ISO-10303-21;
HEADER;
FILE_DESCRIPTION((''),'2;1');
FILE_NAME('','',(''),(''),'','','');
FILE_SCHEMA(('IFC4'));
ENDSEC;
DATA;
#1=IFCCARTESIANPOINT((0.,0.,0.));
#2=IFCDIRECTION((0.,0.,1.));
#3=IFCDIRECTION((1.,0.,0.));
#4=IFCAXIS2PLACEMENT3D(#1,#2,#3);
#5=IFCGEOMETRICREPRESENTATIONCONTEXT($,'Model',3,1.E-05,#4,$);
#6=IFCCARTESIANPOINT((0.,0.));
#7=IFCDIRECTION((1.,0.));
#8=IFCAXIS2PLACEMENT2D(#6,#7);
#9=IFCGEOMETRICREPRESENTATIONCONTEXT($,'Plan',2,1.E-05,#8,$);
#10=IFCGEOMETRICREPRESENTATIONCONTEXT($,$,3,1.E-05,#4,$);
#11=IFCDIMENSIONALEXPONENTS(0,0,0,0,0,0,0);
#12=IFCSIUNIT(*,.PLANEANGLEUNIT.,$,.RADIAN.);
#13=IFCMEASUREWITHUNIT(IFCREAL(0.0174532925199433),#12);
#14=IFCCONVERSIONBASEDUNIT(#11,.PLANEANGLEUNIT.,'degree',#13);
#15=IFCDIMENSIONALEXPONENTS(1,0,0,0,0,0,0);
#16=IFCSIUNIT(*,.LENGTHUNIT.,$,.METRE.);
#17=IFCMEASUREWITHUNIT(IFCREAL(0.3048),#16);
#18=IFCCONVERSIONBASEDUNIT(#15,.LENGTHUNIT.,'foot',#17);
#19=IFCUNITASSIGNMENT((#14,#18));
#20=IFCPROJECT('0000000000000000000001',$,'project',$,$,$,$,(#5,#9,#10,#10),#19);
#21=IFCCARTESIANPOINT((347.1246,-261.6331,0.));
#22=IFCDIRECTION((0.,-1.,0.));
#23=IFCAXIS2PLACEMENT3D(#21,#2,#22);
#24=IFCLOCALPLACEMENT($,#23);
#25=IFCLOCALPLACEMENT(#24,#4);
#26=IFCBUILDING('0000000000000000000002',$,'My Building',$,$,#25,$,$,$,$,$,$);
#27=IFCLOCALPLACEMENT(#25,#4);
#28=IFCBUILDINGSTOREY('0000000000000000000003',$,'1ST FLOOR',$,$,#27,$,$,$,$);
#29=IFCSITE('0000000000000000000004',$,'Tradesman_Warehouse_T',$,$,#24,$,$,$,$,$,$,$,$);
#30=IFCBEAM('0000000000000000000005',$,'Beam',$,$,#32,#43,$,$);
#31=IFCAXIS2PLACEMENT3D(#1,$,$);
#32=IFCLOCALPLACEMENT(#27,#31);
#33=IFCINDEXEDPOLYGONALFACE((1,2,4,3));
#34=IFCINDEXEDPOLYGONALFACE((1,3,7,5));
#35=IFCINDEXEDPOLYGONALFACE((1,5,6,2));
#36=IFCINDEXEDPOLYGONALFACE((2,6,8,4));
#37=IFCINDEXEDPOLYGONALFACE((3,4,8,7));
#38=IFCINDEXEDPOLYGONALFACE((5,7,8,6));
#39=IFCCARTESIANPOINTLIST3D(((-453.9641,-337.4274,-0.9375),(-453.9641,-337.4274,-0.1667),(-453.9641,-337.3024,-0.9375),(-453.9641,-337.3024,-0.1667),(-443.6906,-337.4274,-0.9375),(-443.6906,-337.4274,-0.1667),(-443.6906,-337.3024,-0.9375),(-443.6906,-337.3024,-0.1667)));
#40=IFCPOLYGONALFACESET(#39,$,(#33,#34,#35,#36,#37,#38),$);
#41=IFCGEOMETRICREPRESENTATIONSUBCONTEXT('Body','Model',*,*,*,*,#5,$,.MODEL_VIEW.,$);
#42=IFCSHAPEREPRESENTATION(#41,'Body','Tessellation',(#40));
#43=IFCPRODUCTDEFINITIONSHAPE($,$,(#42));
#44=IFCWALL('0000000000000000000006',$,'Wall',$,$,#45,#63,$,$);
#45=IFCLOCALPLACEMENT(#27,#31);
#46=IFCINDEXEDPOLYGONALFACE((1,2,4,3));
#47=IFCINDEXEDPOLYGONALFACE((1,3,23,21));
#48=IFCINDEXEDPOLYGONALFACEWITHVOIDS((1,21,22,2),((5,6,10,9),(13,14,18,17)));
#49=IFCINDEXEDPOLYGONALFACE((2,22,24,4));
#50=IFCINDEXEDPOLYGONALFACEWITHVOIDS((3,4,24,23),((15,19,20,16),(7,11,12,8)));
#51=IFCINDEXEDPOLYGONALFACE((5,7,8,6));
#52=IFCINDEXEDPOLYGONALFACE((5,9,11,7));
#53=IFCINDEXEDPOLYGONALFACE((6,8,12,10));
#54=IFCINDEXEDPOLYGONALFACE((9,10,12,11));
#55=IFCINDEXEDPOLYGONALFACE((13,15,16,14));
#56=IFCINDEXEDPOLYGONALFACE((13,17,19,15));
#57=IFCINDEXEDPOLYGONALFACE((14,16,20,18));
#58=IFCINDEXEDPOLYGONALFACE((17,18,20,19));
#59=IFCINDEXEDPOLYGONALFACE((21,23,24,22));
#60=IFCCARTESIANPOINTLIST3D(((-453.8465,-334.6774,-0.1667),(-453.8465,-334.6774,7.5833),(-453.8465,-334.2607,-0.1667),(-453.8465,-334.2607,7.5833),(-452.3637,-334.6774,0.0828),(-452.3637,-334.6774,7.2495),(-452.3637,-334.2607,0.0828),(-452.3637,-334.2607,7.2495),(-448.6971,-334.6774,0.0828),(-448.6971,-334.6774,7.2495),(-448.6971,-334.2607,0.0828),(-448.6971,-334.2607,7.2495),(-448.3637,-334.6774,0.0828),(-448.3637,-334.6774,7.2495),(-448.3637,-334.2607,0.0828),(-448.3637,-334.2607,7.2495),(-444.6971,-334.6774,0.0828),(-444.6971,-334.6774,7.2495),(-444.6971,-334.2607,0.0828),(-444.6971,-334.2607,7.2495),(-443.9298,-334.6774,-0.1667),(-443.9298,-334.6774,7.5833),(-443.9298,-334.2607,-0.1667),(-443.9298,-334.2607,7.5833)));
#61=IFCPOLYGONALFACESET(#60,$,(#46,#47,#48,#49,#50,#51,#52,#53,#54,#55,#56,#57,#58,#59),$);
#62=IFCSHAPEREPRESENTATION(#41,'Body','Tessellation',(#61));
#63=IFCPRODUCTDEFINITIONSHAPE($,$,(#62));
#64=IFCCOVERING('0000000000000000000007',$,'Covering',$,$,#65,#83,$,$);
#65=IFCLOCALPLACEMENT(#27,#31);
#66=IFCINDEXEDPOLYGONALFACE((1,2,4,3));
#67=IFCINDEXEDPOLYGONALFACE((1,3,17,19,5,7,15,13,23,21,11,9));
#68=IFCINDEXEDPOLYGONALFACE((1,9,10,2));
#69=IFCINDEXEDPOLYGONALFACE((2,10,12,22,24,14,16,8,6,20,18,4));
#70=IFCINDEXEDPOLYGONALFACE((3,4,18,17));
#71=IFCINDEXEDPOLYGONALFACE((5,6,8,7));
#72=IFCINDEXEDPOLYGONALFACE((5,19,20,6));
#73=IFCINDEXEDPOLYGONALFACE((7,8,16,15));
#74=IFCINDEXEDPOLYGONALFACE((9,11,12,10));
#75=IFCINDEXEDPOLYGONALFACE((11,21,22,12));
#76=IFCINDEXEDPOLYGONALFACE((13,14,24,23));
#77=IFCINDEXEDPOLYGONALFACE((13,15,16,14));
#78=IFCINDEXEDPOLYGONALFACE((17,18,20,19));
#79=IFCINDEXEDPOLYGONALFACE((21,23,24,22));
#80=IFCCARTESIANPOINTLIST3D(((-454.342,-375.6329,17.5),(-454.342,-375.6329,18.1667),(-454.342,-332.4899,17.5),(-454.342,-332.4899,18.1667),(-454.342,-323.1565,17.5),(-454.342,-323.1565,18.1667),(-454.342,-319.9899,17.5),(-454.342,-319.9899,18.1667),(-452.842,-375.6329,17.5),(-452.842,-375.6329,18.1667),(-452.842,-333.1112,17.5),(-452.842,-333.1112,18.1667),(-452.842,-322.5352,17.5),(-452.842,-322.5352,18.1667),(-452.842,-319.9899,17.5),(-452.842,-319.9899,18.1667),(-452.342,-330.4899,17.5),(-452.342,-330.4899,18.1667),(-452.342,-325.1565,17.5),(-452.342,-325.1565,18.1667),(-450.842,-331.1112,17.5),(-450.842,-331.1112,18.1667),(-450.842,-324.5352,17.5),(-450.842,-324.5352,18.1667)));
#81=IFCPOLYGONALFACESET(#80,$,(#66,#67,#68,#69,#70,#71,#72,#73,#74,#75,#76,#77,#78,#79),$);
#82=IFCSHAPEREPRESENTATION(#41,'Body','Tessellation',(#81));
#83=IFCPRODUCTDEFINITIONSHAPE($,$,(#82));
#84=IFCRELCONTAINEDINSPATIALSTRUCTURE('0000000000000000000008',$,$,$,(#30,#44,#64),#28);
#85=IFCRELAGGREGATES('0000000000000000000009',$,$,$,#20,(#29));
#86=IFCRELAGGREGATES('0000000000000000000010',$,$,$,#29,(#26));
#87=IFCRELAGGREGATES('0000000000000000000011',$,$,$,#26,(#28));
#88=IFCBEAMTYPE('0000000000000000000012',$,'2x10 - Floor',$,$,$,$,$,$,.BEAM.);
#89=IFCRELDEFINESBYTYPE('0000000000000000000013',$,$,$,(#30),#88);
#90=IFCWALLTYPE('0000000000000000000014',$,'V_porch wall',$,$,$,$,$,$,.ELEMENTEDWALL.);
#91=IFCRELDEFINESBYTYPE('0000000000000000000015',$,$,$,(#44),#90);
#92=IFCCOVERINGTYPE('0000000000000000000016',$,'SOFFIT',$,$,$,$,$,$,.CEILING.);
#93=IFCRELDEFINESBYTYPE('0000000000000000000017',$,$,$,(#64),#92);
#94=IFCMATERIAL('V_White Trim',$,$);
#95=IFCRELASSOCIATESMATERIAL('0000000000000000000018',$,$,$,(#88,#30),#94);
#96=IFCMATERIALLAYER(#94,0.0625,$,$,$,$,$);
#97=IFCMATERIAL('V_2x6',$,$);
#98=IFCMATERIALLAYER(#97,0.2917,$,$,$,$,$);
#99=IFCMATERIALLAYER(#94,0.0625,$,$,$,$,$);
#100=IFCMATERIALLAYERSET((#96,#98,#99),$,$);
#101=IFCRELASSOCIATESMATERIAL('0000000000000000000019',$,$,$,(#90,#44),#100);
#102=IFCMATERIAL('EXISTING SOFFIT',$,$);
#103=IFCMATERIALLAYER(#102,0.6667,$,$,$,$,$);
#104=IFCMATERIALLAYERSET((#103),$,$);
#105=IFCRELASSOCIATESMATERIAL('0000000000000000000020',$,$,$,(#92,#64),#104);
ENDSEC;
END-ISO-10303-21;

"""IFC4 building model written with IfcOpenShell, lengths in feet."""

from ifc_helpers import new_model, entity, si_unit, converted_unit, frame, origin_with_axes, origin_2d_with_axis, place, context, subcontext, project, spatial, line, indexed_curve, rectangle, outline, extrude, source, transform, mapped, material, layer, layer_set, layer_usage, material_profile, profile_set, profile_usage, type_object, element, save


model = new_model("IFC4")

# Units and contexts
model_context = context("Model", 3, precision=1e-05, world=origin_with_axes())
plan_context = context("Plan", 2, precision=1e-05, world=origin_2d_with_axis())
context_of_model = context(None, 3, precision=1e-05, world=origin_with_axes())
body_context = subcontext(model_context, "Body", "Model", "MODEL_VIEW")
ifc_project = project(units=[converted_unit("PLANEANGLEUNIT", "degree", entity("IfcReal", 0.0174532925199433), si_unit("PLANEANGLEUNIT", "RADIAN"), dimensions=[0, 0, 0, 0, 0, 0, 0]), converted_unit("LENGTHUNIT", "foot", entity("IfcReal", 0.3048), si_unit("LENGTHUNIT", "METRE"), dimensions=[1, 0, 0, 0, 0, 0, 0])], contexts=[model_context, plan_context, context_of_model, context_of_model])

# Site, building, storey
site_placement = place(None, frame((347.1246, -261.6331, 0.0), z_axis=(0.0, 0.0, 1.0), x_axis=(0.0, -1.0, 0.0)))
site = spatial("IfcSite", under=ifc_project, at=site_placement, Name="Tradesman_Warehouse_T")
building_placement = place(site_placement, frame((0.0, 0.0, 0.0), z_axis=(0.0, 0.0, 1.0), x_axis=(1.0, 0.0, 0.0)))
building = spatial("IfcBuilding", under=site, at=building_placement, Name="My Building")
storey_placement = place(building_placement, frame((0.0, 0.0, 0.0), z_axis=(0.0, 0.0, 1.0), x_axis=(1.0, 0.0, 0.0)))
storey = spatial("IfcBuildingStorey", under=building, at=storey_placement, Name="1ST FLOOR")

# Beam
ifc_material_1 = material(Name="V_White Trim")
ifc_material_profile_1 = material_profile(ifc_material_1, rectangle(XDim=0.125, YDim=0.7708))
ifc_profile_set_1 = profile_set([ifc_material_profile_1])
beam_type_1 = type_object("IfcBeamType", Name="2x10 - Floor", PredefinedType="BEAM", material=ifc_profile_set_1)
ifc_profile_usage_1 = profile_usage(ifc_profile_set_1, cardinal=5)
beam_1_placement = place(storey_placement, frame((-453.9641, -337.3649, -0.5521), z_axis=(1.0, 0.0, 0.0), x_axis=(0.0, 1.0, 0.0)))
element("IfcBeam", 1, at=beam_1_placement, inside=storey, type_object=beam_type_1, material=ifc_profile_usage_1, Name="Beam", context=body_context, shape_type="SweptSolid", body=[
    extrude(rectangle(XDim=0.125, YDim=0.7708), origin_with_axes(), (0.0, 0.0, 1.0), 10.2735),
])

# Shared definitions
ifc_material_2 = material(Name="V_2x6")

# Wall, openings
ifc_layer_1 = layer(ifc_material_1, 0.0625)
ifc_layer_2 = layer(ifc_material_2, 0.2917)
ifc_layer_3 = layer(ifc_material_1, 0.0625)
ifc_layer_set_1 = layer_set([ifc_layer_1, ifc_layer_2, ifc_layer_3])
ifc_layer_usage_1 = layer_usage(ifc_layer_set_1, "AXIS2", "POSITIVE", 0.0)
wall_type_1 = type_object("IfcWallType", Name="V_porch wall", PredefinedType="ELEMENTEDWALL", material=ifc_layer_set_1)
wall_1_placement = place(storey_placement, frame((-443.9298, -334.2607, -0.1667), z_axis=(0.0, 0.0, 1.0), x_axis=(-1.0, 0.0, 0.0)))
wall_1 = element("IfcWall", 2, at=wall_1_placement, inside=storey, type_object=wall_type_1, material=ifc_layer_usage_1, Name="Wall", context=body_context, shape_type="SweptSolid", body=[
    extrude(outline(indexed_curve([(0.0, 0.0), (0.0, 0.4167), (9.9167, 0.4167), (9.9167, 0.0), (0.0, 0.0)], self_intersect=False)), origin_with_axes(), (0.0, 0.0, 1.0), 7.75),
])
shared_shape = source(origin_with_axes(), body_context, "Body", "SweptSolid", [
    extrude(outline(indexed_curve([(0.0, 0.0), (3.6667, 0.0), (3.6667, 7.1667), (0.0, 7.1667)], segments=[line(1, 2, 3, 4, 1)])), frame((0.0, -1.9685, 0.0), z_axis=(0.0, -1.0, 0.0), x_axis=(1.0, 0.0, 0.0)), (0.0, 0.0, -1.0), 3.937),
])
opening_1_placement = place(wall_1_placement, frame((0.7673, 0.0, 0.2495), z_axis=(0.0, 0.0, 1.0), x_axis=(1.0, 0.0, 0.0)))
element("IfcOpeningElement", 3, at=opening_1_placement, cuts=wall_1, PredefinedType="OPENING", context=body_context, shape_type="MappedRepresentation", body=[
    mapped(shared_shape, transform((0.0, 0.0, 0.0), x_axis=(1.0, 0.0, 0.0), y_axis=(0.0, 1.0, 0.0), z_axis=(0.0, 0.0, 1.0), scale=1.0)),
])
opening_2_placement = place(wall_1_placement, frame((4.7673, 0.0, 0.2495), z_axis=(0.0, 0.0, 1.0), x_axis=(1.0, 0.0, 0.0)))
element("IfcOpeningElement", 4, at=opening_2_placement, cuts=wall_1, PredefinedType="OPENING", context=body_context, shape_type="MappedRepresentation", body=[
    mapped(shared_shape, transform((0.0, 0.0, 0.0), x_axis=(1.0, 0.0, 0.0), y_axis=(0.0, 1.0, 0.0), z_axis=(0.0, 0.0, 1.0), scale=1.0)),
])

# Covering
ifc_material_3 = material(Name="EXISTING SOFFIT")
ifc_layer_4 = layer(ifc_material_3, 0.6667)
ifc_layer_set_2 = layer_set([ifc_layer_4])
ifc_layer_usage_2 = layer_usage(ifc_layer_set_2, "AXIS3", "POSITIVE", 0.0)
covering_type = type_object("IfcCoveringType", Name="SOFFIT", PredefinedType="CEILING", material=ifc_layer_set_2)
covering_placement = place(storey_placement, frame((-450.842, -331.1112, 17.5), z_axis=(0.0, 0.0, 1.0), x_axis=(0.0, 1.0, 0.0)))
element("IfcCovering", 5, at=covering_placement, inside=storey, type_object=covering_type, material=ifc_layer_usage_2, Name="Covering", context=body_context, shape_type="SweptSolid", body=[
    extrude(outline(indexed_curve([(8.576, 2.0), (6.576, 0.0), (0.0, 0.0), (-2.0, 2.0), (-44.5217, 2.0), (-44.5217, 3.5), (-1.3787, 3.5), (0.6213, 1.5), (5.9547, 1.5), (7.9547, 3.5), (11.1213, 3.5), (11.1213, 2.0), (8.576, 2.0)])), None, (0.0, 0.0, 1.0), 0.6667),
])

save(model, "model.ifc")
